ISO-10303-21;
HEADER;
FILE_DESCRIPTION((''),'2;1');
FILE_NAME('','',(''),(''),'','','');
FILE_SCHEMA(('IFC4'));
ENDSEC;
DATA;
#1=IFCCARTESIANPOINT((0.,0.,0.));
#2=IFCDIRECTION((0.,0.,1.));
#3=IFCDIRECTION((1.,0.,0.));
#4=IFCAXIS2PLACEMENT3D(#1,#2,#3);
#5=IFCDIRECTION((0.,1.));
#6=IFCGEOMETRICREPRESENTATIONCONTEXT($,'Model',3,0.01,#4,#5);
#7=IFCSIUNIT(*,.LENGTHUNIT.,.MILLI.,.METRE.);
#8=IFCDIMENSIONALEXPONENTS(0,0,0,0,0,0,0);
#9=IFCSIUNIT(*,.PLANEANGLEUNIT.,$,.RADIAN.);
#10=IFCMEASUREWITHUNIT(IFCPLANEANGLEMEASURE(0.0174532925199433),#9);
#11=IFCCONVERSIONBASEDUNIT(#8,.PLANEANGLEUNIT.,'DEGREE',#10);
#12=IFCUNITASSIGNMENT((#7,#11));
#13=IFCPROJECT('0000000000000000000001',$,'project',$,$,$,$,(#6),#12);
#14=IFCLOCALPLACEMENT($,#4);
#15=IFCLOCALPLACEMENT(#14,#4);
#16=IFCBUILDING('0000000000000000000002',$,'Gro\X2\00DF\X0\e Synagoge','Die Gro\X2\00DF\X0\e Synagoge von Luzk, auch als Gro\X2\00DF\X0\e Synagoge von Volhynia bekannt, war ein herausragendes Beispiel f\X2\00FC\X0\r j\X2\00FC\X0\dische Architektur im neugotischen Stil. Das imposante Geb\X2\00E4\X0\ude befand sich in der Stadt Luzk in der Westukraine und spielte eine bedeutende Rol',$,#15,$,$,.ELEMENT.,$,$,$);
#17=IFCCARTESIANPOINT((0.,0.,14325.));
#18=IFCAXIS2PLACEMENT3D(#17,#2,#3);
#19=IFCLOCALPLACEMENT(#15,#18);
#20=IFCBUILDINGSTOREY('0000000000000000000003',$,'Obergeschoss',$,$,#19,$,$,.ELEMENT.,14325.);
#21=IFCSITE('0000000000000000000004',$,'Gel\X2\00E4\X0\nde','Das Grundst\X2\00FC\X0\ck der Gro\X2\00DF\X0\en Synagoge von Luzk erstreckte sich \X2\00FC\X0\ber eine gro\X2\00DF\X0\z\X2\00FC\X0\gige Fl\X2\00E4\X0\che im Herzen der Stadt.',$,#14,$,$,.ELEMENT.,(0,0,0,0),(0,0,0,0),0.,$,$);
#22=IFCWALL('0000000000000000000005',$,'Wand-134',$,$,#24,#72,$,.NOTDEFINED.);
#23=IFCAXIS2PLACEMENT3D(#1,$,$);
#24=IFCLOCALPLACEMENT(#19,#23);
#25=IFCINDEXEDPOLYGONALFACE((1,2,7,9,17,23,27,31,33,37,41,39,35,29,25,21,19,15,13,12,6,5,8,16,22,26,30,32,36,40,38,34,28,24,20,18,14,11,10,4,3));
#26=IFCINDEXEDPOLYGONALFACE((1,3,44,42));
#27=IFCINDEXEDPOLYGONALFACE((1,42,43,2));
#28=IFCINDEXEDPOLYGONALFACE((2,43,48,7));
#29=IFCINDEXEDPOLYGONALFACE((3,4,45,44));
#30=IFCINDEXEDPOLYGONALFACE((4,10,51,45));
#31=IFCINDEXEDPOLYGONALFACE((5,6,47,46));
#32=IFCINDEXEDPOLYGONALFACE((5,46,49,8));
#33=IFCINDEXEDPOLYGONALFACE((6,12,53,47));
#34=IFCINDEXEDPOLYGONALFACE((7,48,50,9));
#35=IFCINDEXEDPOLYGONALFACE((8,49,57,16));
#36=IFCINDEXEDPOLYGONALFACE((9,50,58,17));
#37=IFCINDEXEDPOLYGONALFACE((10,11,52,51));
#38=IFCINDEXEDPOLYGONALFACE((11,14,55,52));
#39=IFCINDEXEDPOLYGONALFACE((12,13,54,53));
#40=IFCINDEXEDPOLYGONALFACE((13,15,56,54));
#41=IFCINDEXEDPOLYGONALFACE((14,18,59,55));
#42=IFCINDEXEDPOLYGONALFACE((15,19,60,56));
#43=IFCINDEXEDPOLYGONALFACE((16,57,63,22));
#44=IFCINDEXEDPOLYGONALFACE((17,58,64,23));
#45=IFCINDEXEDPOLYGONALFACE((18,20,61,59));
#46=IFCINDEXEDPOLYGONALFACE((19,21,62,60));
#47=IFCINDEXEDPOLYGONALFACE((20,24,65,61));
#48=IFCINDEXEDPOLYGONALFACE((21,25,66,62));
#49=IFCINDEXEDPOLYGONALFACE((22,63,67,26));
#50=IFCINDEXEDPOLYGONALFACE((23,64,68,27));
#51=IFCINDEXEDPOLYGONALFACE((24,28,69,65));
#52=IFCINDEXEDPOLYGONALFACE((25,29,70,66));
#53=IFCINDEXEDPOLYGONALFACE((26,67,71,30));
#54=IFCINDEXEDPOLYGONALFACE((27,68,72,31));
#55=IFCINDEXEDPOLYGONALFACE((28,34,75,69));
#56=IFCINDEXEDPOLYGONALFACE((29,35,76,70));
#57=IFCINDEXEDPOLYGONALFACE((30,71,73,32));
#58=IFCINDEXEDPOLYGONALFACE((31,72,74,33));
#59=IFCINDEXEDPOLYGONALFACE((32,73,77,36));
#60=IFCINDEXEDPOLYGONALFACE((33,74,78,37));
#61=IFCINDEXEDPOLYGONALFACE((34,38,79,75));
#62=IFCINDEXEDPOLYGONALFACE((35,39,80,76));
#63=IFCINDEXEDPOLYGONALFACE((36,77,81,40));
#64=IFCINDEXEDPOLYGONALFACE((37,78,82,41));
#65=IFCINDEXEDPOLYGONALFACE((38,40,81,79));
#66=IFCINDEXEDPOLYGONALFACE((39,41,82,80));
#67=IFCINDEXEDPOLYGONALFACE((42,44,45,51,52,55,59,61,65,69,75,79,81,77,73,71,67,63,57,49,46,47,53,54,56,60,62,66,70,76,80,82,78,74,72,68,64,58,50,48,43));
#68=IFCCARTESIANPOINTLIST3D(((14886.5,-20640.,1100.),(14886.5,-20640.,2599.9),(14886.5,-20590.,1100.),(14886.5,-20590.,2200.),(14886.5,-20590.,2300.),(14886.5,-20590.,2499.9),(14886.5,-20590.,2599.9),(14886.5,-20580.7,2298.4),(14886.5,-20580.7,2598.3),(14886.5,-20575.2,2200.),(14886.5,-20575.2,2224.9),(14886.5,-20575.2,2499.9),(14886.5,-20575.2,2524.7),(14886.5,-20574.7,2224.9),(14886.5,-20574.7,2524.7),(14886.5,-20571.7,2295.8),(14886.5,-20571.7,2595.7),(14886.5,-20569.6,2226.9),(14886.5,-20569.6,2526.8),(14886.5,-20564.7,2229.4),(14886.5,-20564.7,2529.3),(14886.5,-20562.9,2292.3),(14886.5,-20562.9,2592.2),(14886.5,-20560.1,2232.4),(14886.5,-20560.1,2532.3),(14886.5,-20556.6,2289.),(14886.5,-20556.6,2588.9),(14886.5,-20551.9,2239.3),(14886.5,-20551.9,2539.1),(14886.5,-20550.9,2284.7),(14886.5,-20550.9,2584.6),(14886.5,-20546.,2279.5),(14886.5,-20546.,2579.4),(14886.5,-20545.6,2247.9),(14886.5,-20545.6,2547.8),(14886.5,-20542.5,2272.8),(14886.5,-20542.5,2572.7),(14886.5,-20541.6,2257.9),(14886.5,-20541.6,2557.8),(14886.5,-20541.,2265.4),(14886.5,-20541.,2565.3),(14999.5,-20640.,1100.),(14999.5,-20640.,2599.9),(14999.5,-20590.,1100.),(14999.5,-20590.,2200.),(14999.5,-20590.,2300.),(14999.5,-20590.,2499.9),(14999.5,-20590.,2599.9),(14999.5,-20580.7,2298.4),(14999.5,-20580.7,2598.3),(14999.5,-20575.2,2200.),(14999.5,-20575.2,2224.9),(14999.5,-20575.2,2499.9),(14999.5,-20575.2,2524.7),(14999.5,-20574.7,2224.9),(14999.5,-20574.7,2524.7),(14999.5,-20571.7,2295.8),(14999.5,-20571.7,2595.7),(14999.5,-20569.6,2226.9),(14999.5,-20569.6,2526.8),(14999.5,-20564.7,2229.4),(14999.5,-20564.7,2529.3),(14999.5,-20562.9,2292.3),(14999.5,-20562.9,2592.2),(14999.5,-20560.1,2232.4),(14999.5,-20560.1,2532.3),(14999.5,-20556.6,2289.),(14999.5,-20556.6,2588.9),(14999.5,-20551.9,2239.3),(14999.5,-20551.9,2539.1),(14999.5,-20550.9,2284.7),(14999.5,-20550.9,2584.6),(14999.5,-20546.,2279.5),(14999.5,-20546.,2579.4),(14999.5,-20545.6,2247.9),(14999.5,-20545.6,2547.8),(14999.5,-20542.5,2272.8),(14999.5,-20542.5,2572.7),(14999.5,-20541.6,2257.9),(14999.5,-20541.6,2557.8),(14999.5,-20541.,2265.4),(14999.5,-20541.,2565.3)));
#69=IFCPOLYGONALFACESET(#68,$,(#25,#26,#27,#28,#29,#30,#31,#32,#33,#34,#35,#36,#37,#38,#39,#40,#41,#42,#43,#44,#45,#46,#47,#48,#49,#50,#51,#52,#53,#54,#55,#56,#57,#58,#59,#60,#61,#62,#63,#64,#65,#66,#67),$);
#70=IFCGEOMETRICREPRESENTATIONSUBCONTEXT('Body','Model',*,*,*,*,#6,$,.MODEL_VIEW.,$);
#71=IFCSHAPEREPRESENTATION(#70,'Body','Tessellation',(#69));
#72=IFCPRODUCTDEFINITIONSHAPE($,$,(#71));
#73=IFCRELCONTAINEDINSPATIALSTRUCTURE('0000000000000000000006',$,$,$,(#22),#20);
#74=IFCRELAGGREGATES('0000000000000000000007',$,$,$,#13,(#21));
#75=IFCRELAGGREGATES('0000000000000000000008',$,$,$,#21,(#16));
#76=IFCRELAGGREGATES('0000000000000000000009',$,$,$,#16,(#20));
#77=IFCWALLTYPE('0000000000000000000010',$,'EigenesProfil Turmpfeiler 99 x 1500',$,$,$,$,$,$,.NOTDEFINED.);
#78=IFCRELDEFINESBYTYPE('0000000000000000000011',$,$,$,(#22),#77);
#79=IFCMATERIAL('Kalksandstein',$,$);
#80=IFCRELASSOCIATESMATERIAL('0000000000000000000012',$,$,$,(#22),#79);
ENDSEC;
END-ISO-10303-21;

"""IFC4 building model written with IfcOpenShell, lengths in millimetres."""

from ifc_helpers import new_model, entity, si_unit, converted_unit, direction, frame, origin_with_axes, place, context, subcontext, project, spatial, line, arc, indexed_curve, outline, extrude, material, material_profile, profile_set, type_object, element, save


model = new_model("IFC4")

# Units and contexts
model_context = context("Model", 3, precision=0.01, world=origin_with_axes(), true_north=direction((0.0, 1.0)))
body_context = subcontext(model_context, "Body", "Model", "MODEL_VIEW")
ifc_project = project(units=[si_unit("LENGTHUNIT", "METRE", prefix="MILLI"), converted_unit("PLANEANGLEUNIT", "DEGREE", entity("IfcPlaneAngleMeasure", 0.0174532925199433), si_unit("PLANEANGLEUNIT", "RADIAN"), dimensions=[0, 0, 0, 0, 0, 0, 0])], contexts=[model_context])

# Site, building, storey
site_placement = place(None, origin_with_axes())
site = spatial("IfcSite", under=ifc_project, at=site_placement, Name="Gelände", Description="Das Grundstück der Großen Synagoge von Luzk erstreckte sich über eine großzügige Fläche im Herzen der Stadt.", CompositionType="ELEMENT", RefLatitude=(0, 0, 0, 0), RefLongitude=(0, 0, 0, 0), RefElevation=0.0)
building_placement = place(site_placement, origin_with_axes())
building = spatial("IfcBuilding", under=site, at=building_placement, Name="Große Synagoge", Description="Die Große Synagoge von Luzk, auch als Große Synagoge von Volhynia bekannt, war ein herausragendes Beispiel für jüdische Architektur im neugotischen Stil. Das imposante Gebäude befand sich in der Stadt Luzk in der Westukraine und spielte eine bedeutende Rol", CompositionType="ELEMENT")
storey_placement = place(building_placement, frame((0.0, 0.0, 14325.0), z_axis=(0.0, 0.0, 1.0), x_axis=(1.0, 0.0, 0.0)))
storey = spatial("IfcBuildingStorey", under=building, at=storey_placement, Name="Obergeschoss", CompositionType="ELEMENT", Elevation=14325.0)

# Shared definitions
ifc_material_1 = material(Name="Kalksandstein")

# Wall
ifc_material_profile_1 = material_profile(ifc_material_1, outline(indexed_curve([(65.3, 1424.7), (72.9, 1428.0), (79.9, 1432.3), (91.6, 1443.3), (98.4, 1457.8), (98.5, 1469.1), (94.0, 1479.4), (86.3, 1486.9), (77.1, 1492.2), (63.8, 1497.1), (50.0, 1499.9), (0.0, 1499.9), (0.0, 0.0), (50.0, 0.0), (50.0, 1100.0), (64.8, 1100.0), (64.8, 1124.9), (65.3, 1124.9), (72.9, 1128.1), (79.9, 1132.4), (91.6, 1143.4), (98.4, 1157.9), (98.5, 1169.2), (94.0, 1179.5), (86.3, 1187.0), (77.1, 1192.3), (63.8, 1197.2), (50.0, 1200.0), (50.0, 1399.9), (64.8, 1399.9), (64.8, 1424.7)], segments=[arc(1, 2, 3), arc(3, 4, 5), arc(5, 6, 7), arc(7, 8, 9), arc(9, 10, 11), line(11, 12, 13, 14, 15, 16, 17, 18), arc(18, 19, 20), arc(20, 21, 22), arc(22, 23, 24), arc(24, 25, 26), arc(26, 27, 28), line(28, 29, 30, 31, 1)])), Name="Kalksandstein")
ifc_profile_set_1 = profile_set([ifc_material_profile_1], Name="EigenesProfil Turmpfeiler")
wall_type_1 = type_object("IfcWallType", Name="EigenesProfil Turmpfeiler 99 x 1500", PredefinedType="NOTDEFINED")
wall_1_placement = place(storey_placement, frame((14886.5, -20640.0, 1100.0), z_axis=(0.0, 0.0, 1.0), x_axis=(1.0, 0.0, 0.0)))
element("IfcWall", 1, at=wall_1_placement, inside=storey, type_object=wall_type_1, material=ifc_profile_set_1, Name="Wand-134", PredefinedType="NOTDEFINED", context=body_context, shape_type="SweptSolid", body=[
    extrude(outline(indexed_curve([(65.3, 1424.7), (72.9, 1428.0), (79.9, 1432.3), (91.6, 1443.3), (98.4, 1457.8), (98.5, 1469.1), (94.0, 1479.4), (86.3, 1486.9), (77.1, 1492.2), (63.8, 1497.1), (50.0, 1499.9), (0.0, 1499.9), (0.0, 0.0), (50.0, 0.0), (50.0, 1100.0), (64.8, 1100.0), (64.8, 1124.9), (65.3, 1124.9), (72.9, 1128.1), (79.9, 1132.4), (91.6, 1143.4), (98.4, 1157.9), (98.5, 1169.2), (94.0, 1179.5), (86.3, 1187.0), (77.1, 1192.3), (63.8, 1197.2), (50.0, 1200.0), (50.0, 1399.9), (64.8, 1399.9), (64.8, 1424.7)], segments=[arc(1, 2, 3), arc(3, 4, 5), arc(5, 6, 7), arc(7, 8, 9), arc(9, 10, 11), line(11, 12, 13, 14, 15, 16, 17, 18), arc(18, 19, 20), arc(20, 21, 22), arc(22, 23, 24), arc(24, 25, 26), arc(26, 27, 28), line(28, 29, 30, 31, 1)])), frame((0.0, 0.0, 0.0), z_axis=(1.0, 0.0, 0.0), x_axis=(0.0, 1.0, 0.0)), (0.0, 0.0, 1.0), 113.0),
])

save(model, "model.ifc")
